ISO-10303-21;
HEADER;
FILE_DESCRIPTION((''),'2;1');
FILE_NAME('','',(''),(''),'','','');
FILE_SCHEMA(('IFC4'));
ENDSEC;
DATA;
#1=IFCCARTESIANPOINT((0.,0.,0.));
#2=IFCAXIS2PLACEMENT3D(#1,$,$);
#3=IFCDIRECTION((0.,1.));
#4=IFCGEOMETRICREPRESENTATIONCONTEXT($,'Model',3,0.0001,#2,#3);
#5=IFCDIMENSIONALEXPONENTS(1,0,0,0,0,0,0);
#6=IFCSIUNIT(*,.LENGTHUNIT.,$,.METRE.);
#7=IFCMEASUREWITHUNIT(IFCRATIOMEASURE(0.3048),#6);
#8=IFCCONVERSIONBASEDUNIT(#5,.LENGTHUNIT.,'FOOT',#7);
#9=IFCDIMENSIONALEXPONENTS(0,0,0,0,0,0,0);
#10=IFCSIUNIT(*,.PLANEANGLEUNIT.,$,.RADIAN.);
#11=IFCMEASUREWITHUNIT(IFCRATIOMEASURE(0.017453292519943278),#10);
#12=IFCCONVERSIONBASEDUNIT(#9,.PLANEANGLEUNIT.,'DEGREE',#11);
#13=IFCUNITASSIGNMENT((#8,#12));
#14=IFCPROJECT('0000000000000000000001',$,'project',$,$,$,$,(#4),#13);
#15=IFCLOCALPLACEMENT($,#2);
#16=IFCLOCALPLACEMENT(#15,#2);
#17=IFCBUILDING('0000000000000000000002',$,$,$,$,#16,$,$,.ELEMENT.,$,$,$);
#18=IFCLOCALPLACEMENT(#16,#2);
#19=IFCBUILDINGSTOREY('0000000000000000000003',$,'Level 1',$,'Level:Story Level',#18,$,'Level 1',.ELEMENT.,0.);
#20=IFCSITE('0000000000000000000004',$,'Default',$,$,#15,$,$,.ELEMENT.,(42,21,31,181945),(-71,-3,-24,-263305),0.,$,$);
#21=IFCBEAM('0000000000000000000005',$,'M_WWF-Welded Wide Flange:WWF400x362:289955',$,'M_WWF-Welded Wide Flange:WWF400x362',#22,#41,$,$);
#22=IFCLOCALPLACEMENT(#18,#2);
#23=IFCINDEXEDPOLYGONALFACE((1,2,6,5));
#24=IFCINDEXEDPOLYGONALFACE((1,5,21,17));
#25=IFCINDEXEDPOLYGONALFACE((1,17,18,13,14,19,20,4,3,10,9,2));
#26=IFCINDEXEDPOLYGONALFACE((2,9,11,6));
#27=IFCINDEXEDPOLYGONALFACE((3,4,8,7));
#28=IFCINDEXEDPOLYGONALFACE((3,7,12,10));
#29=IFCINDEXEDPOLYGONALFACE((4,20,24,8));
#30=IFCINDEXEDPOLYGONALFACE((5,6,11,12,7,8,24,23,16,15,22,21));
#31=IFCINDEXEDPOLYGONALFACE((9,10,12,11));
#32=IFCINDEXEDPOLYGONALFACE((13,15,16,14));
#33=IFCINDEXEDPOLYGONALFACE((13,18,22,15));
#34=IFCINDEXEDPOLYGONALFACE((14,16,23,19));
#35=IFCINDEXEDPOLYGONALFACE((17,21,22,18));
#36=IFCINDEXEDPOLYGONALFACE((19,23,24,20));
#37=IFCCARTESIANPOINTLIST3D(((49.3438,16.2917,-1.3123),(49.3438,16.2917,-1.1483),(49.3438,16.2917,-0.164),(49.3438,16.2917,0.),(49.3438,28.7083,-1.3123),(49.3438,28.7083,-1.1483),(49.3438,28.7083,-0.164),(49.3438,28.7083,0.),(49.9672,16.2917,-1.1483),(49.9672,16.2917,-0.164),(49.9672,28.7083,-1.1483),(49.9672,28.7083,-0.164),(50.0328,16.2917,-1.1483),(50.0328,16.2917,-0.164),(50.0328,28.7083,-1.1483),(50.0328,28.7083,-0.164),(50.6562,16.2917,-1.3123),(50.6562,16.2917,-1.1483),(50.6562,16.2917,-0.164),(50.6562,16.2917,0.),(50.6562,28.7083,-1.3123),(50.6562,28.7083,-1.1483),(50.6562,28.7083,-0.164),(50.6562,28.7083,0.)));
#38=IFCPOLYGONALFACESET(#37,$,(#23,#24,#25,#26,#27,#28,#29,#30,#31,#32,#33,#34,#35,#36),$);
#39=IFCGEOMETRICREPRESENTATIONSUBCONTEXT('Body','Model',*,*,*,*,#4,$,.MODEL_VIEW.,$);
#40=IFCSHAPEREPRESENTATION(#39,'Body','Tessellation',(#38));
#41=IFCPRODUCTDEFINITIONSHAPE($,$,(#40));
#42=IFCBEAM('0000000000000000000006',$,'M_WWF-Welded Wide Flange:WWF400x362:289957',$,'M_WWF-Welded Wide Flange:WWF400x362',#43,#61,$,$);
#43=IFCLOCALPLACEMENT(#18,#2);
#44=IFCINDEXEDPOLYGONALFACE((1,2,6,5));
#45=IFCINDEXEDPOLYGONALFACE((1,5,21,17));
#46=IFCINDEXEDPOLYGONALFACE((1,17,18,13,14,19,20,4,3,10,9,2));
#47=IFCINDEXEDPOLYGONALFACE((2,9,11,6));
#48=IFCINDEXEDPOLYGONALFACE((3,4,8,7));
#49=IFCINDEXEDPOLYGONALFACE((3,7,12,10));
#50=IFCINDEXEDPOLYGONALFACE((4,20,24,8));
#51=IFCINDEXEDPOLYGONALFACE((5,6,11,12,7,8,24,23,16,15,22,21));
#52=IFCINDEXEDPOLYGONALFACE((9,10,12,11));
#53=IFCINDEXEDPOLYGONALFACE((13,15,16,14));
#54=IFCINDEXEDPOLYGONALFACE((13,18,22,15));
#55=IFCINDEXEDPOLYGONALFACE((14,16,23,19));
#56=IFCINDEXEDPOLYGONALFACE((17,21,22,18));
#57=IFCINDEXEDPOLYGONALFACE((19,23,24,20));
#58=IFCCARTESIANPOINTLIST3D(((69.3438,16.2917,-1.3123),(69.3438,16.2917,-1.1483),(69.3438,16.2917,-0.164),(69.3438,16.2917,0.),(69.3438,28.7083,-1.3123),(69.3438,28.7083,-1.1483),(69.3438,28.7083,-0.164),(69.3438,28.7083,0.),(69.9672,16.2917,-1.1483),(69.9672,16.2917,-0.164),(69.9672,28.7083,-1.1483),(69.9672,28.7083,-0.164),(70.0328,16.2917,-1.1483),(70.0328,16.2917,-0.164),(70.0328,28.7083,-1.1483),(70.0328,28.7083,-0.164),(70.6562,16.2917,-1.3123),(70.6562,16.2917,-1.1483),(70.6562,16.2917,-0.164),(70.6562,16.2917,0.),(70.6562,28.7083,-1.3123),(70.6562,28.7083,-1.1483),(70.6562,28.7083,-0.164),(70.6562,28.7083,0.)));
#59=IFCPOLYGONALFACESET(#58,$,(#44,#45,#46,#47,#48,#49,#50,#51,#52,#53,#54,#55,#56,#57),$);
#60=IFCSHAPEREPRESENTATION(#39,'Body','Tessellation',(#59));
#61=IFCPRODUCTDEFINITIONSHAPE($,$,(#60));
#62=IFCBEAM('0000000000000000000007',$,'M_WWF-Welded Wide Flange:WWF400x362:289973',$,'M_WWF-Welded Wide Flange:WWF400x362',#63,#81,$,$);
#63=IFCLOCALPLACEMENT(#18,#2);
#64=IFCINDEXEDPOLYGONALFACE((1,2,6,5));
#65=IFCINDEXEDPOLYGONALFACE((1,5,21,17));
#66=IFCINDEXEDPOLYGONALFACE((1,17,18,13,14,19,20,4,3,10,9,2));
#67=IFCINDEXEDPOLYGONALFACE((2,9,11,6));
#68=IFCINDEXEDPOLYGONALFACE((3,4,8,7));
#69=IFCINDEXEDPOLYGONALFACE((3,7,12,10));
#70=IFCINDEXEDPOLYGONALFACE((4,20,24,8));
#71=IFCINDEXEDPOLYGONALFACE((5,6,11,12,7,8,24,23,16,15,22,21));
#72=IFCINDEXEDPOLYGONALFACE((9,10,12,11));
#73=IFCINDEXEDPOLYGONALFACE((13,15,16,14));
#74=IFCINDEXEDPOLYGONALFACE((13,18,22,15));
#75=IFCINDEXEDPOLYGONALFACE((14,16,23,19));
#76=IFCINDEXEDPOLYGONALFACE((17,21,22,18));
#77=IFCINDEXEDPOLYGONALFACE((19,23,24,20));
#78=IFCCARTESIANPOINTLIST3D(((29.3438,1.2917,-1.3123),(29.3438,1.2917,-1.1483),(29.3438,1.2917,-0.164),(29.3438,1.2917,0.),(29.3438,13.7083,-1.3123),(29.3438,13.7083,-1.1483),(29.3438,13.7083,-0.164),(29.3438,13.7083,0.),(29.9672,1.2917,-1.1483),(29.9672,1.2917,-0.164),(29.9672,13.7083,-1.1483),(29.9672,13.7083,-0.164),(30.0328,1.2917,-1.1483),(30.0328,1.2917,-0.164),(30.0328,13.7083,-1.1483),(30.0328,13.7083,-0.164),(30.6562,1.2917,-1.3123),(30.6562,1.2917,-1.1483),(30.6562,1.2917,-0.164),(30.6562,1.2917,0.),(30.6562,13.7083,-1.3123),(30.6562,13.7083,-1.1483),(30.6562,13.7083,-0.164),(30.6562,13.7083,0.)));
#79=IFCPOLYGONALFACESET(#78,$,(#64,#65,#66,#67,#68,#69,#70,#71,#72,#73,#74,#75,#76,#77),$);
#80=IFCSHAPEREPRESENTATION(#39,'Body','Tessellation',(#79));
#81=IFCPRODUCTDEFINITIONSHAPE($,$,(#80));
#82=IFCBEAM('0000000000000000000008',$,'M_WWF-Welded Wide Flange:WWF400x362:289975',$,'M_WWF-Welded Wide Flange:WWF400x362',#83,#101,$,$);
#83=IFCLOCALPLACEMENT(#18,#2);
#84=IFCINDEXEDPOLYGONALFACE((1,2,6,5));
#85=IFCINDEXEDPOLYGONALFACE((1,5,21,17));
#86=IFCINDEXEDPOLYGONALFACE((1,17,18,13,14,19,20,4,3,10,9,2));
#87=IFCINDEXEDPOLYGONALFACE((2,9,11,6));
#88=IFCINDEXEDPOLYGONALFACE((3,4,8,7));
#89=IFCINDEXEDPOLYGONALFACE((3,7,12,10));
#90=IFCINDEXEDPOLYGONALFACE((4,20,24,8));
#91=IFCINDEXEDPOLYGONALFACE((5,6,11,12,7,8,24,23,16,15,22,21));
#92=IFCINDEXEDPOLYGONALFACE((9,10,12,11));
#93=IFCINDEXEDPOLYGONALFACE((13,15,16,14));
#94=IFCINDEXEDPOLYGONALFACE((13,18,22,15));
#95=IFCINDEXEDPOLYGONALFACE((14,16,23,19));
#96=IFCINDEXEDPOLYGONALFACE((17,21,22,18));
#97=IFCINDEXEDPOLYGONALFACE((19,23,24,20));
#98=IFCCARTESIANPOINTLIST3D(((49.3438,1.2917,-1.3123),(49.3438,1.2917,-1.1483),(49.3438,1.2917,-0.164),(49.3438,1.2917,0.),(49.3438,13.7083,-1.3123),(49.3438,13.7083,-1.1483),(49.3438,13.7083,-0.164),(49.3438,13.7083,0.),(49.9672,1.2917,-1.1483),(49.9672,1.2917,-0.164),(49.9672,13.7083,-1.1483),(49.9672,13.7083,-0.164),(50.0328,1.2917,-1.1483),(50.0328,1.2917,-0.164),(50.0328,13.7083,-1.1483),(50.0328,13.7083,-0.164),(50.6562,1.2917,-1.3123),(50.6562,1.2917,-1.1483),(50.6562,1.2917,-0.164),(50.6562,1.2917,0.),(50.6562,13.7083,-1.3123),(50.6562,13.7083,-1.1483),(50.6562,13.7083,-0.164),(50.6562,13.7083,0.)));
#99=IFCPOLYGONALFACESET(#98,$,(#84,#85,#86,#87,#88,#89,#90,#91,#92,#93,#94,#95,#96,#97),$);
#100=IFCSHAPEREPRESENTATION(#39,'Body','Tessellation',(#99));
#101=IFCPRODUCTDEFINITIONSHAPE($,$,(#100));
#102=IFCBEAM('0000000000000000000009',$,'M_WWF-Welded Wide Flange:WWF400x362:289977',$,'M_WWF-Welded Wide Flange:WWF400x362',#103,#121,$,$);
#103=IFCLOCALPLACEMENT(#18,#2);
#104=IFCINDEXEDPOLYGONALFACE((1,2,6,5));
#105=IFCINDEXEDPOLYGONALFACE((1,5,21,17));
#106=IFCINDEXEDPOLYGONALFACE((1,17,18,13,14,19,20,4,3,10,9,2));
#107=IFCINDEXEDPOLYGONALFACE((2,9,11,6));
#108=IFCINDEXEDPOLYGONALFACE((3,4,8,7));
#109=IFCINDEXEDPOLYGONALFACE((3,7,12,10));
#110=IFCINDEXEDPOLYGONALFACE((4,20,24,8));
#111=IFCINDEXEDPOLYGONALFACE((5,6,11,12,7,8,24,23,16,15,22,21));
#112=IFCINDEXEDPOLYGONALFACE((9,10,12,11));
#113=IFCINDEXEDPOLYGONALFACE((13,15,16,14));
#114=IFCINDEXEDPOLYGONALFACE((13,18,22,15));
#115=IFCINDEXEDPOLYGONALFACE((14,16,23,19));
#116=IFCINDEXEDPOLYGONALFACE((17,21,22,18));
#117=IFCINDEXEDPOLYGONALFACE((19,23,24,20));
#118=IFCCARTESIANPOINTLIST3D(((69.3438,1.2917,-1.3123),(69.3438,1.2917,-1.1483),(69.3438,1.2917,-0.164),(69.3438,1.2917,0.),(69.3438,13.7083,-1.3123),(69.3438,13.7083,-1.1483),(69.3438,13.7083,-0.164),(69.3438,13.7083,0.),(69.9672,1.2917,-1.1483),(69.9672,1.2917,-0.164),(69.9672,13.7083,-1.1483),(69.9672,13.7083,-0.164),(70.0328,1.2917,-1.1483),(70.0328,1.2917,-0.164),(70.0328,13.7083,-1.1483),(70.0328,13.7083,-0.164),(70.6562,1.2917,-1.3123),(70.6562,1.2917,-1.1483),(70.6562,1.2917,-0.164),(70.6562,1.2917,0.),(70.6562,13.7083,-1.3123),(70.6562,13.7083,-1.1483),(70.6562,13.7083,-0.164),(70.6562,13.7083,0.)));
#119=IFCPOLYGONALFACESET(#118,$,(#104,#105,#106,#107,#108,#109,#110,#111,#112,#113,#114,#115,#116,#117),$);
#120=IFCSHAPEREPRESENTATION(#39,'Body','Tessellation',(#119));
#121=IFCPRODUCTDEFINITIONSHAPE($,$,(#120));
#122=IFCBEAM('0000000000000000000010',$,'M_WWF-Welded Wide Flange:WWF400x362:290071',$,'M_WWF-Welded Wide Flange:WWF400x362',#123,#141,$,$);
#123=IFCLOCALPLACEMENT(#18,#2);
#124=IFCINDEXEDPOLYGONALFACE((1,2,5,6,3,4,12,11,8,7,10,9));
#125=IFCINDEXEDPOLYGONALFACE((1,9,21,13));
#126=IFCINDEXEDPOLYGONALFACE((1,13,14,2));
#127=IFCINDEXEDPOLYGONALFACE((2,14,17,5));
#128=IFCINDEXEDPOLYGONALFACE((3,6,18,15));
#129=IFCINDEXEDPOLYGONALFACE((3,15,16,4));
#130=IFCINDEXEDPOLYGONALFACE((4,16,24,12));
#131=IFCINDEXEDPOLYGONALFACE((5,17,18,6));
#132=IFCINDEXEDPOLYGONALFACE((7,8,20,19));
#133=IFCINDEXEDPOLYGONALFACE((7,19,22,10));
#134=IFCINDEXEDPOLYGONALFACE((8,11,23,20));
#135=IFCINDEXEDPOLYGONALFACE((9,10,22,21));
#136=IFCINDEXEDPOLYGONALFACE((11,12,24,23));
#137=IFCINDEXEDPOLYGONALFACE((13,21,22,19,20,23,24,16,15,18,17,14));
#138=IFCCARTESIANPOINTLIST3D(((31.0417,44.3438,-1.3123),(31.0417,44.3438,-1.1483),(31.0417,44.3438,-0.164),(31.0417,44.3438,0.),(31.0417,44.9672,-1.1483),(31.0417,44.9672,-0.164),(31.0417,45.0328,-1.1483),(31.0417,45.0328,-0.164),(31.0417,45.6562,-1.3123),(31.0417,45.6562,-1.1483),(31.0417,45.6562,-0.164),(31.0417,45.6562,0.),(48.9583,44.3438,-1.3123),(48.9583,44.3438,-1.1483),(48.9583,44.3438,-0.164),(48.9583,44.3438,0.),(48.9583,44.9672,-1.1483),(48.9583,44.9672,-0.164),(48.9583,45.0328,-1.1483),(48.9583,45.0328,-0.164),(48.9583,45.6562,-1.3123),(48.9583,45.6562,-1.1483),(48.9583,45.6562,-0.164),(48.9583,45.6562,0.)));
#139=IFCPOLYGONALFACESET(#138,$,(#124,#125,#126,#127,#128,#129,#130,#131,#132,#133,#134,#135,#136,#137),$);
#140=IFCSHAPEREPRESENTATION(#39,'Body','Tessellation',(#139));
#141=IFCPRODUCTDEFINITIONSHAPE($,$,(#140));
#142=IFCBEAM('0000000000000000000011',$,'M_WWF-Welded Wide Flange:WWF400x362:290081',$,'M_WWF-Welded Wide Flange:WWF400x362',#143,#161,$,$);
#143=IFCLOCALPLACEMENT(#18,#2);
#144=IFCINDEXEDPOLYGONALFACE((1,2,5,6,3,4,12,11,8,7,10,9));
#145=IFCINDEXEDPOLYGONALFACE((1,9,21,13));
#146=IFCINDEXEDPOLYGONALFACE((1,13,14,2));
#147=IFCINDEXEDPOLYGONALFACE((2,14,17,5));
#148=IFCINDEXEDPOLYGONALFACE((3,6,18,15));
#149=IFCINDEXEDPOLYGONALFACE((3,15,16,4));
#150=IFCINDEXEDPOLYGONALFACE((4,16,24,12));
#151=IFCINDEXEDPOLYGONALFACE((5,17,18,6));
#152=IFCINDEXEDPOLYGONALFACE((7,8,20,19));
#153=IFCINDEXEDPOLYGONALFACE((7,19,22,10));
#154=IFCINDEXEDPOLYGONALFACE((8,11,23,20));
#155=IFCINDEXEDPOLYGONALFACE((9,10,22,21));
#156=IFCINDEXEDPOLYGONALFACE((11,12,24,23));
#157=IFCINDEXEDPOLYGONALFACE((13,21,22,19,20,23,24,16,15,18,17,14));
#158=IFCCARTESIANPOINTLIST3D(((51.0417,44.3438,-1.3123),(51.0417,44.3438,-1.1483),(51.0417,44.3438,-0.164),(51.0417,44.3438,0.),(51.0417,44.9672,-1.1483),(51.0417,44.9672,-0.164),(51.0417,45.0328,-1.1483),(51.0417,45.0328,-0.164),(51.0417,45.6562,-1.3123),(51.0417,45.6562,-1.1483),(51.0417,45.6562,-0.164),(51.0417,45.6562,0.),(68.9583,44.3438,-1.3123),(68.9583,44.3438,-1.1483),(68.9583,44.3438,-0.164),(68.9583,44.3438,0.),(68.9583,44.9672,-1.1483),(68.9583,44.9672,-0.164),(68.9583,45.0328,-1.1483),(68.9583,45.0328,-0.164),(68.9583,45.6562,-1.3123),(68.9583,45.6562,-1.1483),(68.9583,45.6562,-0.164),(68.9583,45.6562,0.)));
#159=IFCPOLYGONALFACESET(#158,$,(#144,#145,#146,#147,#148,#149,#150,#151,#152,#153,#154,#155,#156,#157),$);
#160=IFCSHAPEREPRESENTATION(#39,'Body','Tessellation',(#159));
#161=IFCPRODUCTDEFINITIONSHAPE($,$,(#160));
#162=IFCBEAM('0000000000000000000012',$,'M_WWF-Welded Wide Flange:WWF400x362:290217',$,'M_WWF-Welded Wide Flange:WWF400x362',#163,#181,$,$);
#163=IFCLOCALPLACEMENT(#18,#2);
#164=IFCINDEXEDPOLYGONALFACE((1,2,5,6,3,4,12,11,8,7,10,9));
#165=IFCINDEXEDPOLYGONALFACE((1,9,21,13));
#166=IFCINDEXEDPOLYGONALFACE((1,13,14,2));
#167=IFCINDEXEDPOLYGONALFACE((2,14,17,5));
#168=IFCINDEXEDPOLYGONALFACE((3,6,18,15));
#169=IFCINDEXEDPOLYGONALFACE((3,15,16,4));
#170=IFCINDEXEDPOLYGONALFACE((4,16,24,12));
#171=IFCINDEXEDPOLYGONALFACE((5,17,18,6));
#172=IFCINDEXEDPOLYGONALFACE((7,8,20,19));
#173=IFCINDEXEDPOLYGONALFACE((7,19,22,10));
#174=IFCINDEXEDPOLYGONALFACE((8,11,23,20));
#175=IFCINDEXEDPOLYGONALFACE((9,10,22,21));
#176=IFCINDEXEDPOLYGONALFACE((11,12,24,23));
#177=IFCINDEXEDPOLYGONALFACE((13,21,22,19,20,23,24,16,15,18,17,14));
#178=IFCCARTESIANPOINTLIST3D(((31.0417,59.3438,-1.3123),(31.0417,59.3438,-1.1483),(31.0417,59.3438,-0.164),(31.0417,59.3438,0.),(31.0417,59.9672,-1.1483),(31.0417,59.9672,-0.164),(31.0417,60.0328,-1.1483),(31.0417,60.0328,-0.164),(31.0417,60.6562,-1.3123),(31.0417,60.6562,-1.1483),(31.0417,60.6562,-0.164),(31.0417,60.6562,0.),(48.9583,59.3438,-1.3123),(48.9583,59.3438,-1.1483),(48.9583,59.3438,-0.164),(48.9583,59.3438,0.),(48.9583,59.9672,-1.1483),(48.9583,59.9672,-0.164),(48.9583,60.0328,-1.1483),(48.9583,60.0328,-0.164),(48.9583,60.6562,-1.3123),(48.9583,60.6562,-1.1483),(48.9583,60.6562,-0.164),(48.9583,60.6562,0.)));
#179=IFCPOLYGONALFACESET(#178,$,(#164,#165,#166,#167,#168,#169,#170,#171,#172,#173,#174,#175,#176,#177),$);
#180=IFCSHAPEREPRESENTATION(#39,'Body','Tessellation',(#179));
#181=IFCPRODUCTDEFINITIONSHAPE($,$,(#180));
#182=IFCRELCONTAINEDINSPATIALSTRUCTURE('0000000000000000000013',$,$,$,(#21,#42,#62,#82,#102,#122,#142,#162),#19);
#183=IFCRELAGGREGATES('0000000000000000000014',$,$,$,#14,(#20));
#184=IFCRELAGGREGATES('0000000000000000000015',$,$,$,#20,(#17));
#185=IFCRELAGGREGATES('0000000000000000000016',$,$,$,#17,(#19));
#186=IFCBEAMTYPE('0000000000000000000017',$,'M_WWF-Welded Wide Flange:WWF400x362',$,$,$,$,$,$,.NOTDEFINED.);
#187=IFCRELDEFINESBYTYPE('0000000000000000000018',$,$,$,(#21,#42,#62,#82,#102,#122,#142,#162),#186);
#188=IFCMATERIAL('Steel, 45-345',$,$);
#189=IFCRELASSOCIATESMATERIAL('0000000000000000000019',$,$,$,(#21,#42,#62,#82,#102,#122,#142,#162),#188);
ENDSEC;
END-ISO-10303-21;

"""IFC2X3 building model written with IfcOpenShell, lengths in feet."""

from ifc_helpers import new_model, entity, si_unit, converted_unit, direction, frame, frame_2d, origin, place, context, subcontext, project, spatial, i_section, extrude, material, type_object, element, save


model = new_model("IFC2X3")

# Units and contexts
model_context = context("Model", 3, precision=0.0001, world=origin(), true_north=direction((0.0, 1.0)))
body_context = subcontext(model_context, "Body", "Model", "MODEL_VIEW")
ifc_project = project(units=[converted_unit("LENGTHUNIT", "FOOT", entity("IfcRatioMeasure", 0.3048), si_unit("LENGTHUNIT", "METRE"), dimensions=[1, 0, 0, 0, 0, 0, 0]), converted_unit("PLANEANGLEUNIT", "DEGREE", entity("IfcRatioMeasure", 0.017453292519943278), si_unit("PLANEANGLEUNIT", "RADIAN"), dimensions=[0, 0, 0, 0, 0, 0, 0])], contexts=[model_context])

# Site, building, storey
site_placement = place(None, origin())
site = spatial("IfcSite", under=ifc_project, at=site_placement, Name="Default", CompositionType="ELEMENT", RefLatitude=(42, 21, 31, 181945), RefLongitude=(-71, -3, -24, -263305), RefElevation=0.0)
building_placement = place(site_placement, origin())
building = spatial("IfcBuilding", under=site, at=building_placement, CompositionType="ELEMENT")
storey_placement = place(building_placement, origin())
storey = spatial("IfcBuildingStorey", under=building, at=storey_placement, Name="Level 1", ObjectType="Level:Story Level", LongName="Level 1", CompositionType="ELEMENT", Elevation=0.0)

# Shared definitions
ifc_material = material(Name="Steel, 45-345")

# Beams
beam_type = type_object("IfcBeamType", Name="M_WWF-Welded Wide Flange:WWF400x362", PredefinedType="NOTDEFINED")
beam_1_placement = place(storey_placement, frame((50.0, 15.0, 0.0), z_axis=(0.0, 0.0, 1.0), x_axis=(0.0, 1.0, 0.0)))
element("IfcBeam", 1, at=beam_1_placement, inside=storey, type_object=beam_type, material=ifc_material, Name="M_WWF-Welded Wide Flange:WWF400x362:289955", ObjectType="M_WWF-Welded Wide Flange:WWF400x362", context=body_context, shape_type="SweptSolid", body=[
    extrude(i_section(OverallWidth=1.3123, OverallDepth=1.3123, WebThickness=0.0656, FlangeThickness=0.164, at=frame_2d((0.0, 0.0), x_axis=(0.0, 1.0))), frame((1.2917, 0.0, -0.6562), z_axis=(1.0, 0.0, 0.0), x_axis=(0.0, 0.0, -1.0)), (0.0, 0.0, 1.0), 12.4167),
])
beam_2_placement = place(storey_placement, frame((70.0, 15.0, 0.0), z_axis=(0.0, 0.0, 1.0), x_axis=(0.0, 1.0, 0.0)))
element("IfcBeam", 2, at=beam_2_placement, inside=storey, type_object=beam_type, material=ifc_material, Name="M_WWF-Welded Wide Flange:WWF400x362:289957", ObjectType="M_WWF-Welded Wide Flange:WWF400x362", context=body_context, shape_type="SweptSolid", body=[
    extrude(i_section(OverallWidth=1.3123, OverallDepth=1.3123, WebThickness=0.0656, FlangeThickness=0.164, at=frame_2d((0.0, 0.0), x_axis=(0.0, 1.0))), frame((1.2917, 0.0, -0.6562), z_axis=(1.0, 0.0, 0.0), x_axis=(0.0, 0.0, -1.0)), (0.0, 0.0, 1.0), 12.4167),
])
beam_3_placement = place(storey_placement, frame((30.0, 0.0, 0.0), z_axis=(0.0, 0.0, 1.0), x_axis=(0.0, 1.0, 0.0)))
element("IfcBeam", 3, at=beam_3_placement, inside=storey, type_object=beam_type, material=ifc_material, Name="M_WWF-Welded Wide Flange:WWF400x362:289973", ObjectType="M_WWF-Welded Wide Flange:WWF400x362", context=body_context, shape_type="SweptSolid", body=[
    extrude(i_section(OverallWidth=1.3123, OverallDepth=1.3123, WebThickness=0.0656, FlangeThickness=0.164, at=frame_2d((0.0, 0.0), x_axis=(0.0, 1.0))), frame((1.2917, 0.0, -0.6562), z_axis=(1.0, 0.0, 0.0), x_axis=(0.0, 0.0, -1.0)), (0.0, 0.0, 1.0), 12.4167),
])
beam_4_placement = place(storey_placement, frame((50.0, 0.0, 0.0), z_axis=(0.0, 0.0, 1.0), x_axis=(0.0, 1.0, 0.0)))
element("IfcBeam", 4, at=beam_4_placement, inside=storey, type_object=beam_type, material=ifc_material, Name="M_WWF-Welded Wide Flange:WWF400x362:289975", ObjectType="M_WWF-Welded Wide Flange:WWF400x362", context=body_context, shape_type="SweptSolid", body=[
    extrude(i_section(OverallWidth=1.3123, OverallDepth=1.3123, WebThickness=0.0656, FlangeThickness=0.164, at=frame_2d((0.0, 0.0), x_axis=(0.0, 1.0))), frame((1.2917, 0.0, -0.6562), z_axis=(1.0, 0.0, 0.0), x_axis=(0.0, 0.0, -1.0)), (0.0, 0.0, 1.0), 12.4167),
])
beam_5_placement = place(storey_placement, frame((70.0, 0.0, 0.0), z_axis=(0.0, 0.0, 1.0), x_axis=(0.0, 1.0, 0.0)))
element("IfcBeam", 5, at=beam_5_placement, inside=storey, type_object=beam_type, material=ifc_material, Name="M_WWF-Welded Wide Flange:WWF400x362:289977", ObjectType="M_WWF-Welded Wide Flange:WWF400x362", context=body_context, shape_type="SweptSolid", body=[
    extrude(i_section(OverallWidth=1.3123, OverallDepth=1.3123, WebThickness=0.0656, FlangeThickness=0.164, at=frame_2d((0.0, 0.0), x_axis=(0.0, 1.0))), frame((1.2917, 0.0, -0.6562), z_axis=(1.0, 0.0, 0.0), x_axis=(0.0, 0.0, -1.0)), (0.0, 0.0, 1.0), 12.4167),
])
beam_6_placement = place(storey_placement, frame((30.0, 45.0, 0.0)))
element("IfcBeam", 6, at=beam_6_placement, inside=storey, type_object=beam_type, material=ifc_material, Name="M_WWF-Welded Wide Flange:WWF400x362:290071", ObjectType="M_WWF-Welded Wide Flange:WWF400x362", context=body_context, shape_type="SweptSolid", body=[
    extrude(i_section(OverallWidth=1.3123, OverallDepth=1.3123, WebThickness=0.0656, FlangeThickness=0.164, at=frame_2d((0.0, 0.0), x_axis=(0.0, 1.0))), frame((1.0417, 0.0, -0.6562), z_axis=(1.0, 0.0, 0.0), x_axis=(0.0, 0.0, -1.0)), (0.0, 0.0, 1.0), 17.9167),
])
beam_7_placement = place(storey_placement, frame((50.0, 45.0, 0.0)))
element("IfcBeam", 7, at=beam_7_placement, inside=storey, type_object=beam_type, material=ifc_material, Name="M_WWF-Welded Wide Flange:WWF400x362:290081", ObjectType="M_WWF-Welded Wide Flange:WWF400x362", context=body_context, shape_type="SweptSolid", body=[
    extrude(i_section(OverallWidth=1.3123, OverallDepth=1.3123, WebThickness=0.0656, FlangeThickness=0.164, at=frame_2d((0.0, 0.0), x_axis=(0.0, 1.0))), frame((1.0417, 0.0, -0.6562), z_axis=(1.0, 0.0, 0.0), x_axis=(0.0, 0.0, -1.0)), (0.0, 0.0, 1.0), 17.9167),
])
beam_8_placement = place(storey_placement, frame((30.0, 60.0, 0.0)))
element("IfcBeam", 8, at=beam_8_placement, inside=storey, type_object=beam_type, material=ifc_material, Name="M_WWF-Welded Wide Flange:WWF400x362:290217", ObjectType="M_WWF-Welded Wide Flange:WWF400x362", context=body_context, shape_type="SweptSolid", body=[
    extrude(i_section(OverallWidth=1.3123, OverallDepth=1.3123, WebThickness=0.0656, FlangeThickness=0.164, at=frame_2d((0.0, 0.0), x_axis=(0.0, 1.0))), frame((1.0417, 0.0, -0.6562), z_axis=(1.0, 0.0, 0.0), x_axis=(0.0, 0.0, -1.0)), (0.0, 0.0, 1.0), 17.9167),
])

save(model, "model.ifc")
